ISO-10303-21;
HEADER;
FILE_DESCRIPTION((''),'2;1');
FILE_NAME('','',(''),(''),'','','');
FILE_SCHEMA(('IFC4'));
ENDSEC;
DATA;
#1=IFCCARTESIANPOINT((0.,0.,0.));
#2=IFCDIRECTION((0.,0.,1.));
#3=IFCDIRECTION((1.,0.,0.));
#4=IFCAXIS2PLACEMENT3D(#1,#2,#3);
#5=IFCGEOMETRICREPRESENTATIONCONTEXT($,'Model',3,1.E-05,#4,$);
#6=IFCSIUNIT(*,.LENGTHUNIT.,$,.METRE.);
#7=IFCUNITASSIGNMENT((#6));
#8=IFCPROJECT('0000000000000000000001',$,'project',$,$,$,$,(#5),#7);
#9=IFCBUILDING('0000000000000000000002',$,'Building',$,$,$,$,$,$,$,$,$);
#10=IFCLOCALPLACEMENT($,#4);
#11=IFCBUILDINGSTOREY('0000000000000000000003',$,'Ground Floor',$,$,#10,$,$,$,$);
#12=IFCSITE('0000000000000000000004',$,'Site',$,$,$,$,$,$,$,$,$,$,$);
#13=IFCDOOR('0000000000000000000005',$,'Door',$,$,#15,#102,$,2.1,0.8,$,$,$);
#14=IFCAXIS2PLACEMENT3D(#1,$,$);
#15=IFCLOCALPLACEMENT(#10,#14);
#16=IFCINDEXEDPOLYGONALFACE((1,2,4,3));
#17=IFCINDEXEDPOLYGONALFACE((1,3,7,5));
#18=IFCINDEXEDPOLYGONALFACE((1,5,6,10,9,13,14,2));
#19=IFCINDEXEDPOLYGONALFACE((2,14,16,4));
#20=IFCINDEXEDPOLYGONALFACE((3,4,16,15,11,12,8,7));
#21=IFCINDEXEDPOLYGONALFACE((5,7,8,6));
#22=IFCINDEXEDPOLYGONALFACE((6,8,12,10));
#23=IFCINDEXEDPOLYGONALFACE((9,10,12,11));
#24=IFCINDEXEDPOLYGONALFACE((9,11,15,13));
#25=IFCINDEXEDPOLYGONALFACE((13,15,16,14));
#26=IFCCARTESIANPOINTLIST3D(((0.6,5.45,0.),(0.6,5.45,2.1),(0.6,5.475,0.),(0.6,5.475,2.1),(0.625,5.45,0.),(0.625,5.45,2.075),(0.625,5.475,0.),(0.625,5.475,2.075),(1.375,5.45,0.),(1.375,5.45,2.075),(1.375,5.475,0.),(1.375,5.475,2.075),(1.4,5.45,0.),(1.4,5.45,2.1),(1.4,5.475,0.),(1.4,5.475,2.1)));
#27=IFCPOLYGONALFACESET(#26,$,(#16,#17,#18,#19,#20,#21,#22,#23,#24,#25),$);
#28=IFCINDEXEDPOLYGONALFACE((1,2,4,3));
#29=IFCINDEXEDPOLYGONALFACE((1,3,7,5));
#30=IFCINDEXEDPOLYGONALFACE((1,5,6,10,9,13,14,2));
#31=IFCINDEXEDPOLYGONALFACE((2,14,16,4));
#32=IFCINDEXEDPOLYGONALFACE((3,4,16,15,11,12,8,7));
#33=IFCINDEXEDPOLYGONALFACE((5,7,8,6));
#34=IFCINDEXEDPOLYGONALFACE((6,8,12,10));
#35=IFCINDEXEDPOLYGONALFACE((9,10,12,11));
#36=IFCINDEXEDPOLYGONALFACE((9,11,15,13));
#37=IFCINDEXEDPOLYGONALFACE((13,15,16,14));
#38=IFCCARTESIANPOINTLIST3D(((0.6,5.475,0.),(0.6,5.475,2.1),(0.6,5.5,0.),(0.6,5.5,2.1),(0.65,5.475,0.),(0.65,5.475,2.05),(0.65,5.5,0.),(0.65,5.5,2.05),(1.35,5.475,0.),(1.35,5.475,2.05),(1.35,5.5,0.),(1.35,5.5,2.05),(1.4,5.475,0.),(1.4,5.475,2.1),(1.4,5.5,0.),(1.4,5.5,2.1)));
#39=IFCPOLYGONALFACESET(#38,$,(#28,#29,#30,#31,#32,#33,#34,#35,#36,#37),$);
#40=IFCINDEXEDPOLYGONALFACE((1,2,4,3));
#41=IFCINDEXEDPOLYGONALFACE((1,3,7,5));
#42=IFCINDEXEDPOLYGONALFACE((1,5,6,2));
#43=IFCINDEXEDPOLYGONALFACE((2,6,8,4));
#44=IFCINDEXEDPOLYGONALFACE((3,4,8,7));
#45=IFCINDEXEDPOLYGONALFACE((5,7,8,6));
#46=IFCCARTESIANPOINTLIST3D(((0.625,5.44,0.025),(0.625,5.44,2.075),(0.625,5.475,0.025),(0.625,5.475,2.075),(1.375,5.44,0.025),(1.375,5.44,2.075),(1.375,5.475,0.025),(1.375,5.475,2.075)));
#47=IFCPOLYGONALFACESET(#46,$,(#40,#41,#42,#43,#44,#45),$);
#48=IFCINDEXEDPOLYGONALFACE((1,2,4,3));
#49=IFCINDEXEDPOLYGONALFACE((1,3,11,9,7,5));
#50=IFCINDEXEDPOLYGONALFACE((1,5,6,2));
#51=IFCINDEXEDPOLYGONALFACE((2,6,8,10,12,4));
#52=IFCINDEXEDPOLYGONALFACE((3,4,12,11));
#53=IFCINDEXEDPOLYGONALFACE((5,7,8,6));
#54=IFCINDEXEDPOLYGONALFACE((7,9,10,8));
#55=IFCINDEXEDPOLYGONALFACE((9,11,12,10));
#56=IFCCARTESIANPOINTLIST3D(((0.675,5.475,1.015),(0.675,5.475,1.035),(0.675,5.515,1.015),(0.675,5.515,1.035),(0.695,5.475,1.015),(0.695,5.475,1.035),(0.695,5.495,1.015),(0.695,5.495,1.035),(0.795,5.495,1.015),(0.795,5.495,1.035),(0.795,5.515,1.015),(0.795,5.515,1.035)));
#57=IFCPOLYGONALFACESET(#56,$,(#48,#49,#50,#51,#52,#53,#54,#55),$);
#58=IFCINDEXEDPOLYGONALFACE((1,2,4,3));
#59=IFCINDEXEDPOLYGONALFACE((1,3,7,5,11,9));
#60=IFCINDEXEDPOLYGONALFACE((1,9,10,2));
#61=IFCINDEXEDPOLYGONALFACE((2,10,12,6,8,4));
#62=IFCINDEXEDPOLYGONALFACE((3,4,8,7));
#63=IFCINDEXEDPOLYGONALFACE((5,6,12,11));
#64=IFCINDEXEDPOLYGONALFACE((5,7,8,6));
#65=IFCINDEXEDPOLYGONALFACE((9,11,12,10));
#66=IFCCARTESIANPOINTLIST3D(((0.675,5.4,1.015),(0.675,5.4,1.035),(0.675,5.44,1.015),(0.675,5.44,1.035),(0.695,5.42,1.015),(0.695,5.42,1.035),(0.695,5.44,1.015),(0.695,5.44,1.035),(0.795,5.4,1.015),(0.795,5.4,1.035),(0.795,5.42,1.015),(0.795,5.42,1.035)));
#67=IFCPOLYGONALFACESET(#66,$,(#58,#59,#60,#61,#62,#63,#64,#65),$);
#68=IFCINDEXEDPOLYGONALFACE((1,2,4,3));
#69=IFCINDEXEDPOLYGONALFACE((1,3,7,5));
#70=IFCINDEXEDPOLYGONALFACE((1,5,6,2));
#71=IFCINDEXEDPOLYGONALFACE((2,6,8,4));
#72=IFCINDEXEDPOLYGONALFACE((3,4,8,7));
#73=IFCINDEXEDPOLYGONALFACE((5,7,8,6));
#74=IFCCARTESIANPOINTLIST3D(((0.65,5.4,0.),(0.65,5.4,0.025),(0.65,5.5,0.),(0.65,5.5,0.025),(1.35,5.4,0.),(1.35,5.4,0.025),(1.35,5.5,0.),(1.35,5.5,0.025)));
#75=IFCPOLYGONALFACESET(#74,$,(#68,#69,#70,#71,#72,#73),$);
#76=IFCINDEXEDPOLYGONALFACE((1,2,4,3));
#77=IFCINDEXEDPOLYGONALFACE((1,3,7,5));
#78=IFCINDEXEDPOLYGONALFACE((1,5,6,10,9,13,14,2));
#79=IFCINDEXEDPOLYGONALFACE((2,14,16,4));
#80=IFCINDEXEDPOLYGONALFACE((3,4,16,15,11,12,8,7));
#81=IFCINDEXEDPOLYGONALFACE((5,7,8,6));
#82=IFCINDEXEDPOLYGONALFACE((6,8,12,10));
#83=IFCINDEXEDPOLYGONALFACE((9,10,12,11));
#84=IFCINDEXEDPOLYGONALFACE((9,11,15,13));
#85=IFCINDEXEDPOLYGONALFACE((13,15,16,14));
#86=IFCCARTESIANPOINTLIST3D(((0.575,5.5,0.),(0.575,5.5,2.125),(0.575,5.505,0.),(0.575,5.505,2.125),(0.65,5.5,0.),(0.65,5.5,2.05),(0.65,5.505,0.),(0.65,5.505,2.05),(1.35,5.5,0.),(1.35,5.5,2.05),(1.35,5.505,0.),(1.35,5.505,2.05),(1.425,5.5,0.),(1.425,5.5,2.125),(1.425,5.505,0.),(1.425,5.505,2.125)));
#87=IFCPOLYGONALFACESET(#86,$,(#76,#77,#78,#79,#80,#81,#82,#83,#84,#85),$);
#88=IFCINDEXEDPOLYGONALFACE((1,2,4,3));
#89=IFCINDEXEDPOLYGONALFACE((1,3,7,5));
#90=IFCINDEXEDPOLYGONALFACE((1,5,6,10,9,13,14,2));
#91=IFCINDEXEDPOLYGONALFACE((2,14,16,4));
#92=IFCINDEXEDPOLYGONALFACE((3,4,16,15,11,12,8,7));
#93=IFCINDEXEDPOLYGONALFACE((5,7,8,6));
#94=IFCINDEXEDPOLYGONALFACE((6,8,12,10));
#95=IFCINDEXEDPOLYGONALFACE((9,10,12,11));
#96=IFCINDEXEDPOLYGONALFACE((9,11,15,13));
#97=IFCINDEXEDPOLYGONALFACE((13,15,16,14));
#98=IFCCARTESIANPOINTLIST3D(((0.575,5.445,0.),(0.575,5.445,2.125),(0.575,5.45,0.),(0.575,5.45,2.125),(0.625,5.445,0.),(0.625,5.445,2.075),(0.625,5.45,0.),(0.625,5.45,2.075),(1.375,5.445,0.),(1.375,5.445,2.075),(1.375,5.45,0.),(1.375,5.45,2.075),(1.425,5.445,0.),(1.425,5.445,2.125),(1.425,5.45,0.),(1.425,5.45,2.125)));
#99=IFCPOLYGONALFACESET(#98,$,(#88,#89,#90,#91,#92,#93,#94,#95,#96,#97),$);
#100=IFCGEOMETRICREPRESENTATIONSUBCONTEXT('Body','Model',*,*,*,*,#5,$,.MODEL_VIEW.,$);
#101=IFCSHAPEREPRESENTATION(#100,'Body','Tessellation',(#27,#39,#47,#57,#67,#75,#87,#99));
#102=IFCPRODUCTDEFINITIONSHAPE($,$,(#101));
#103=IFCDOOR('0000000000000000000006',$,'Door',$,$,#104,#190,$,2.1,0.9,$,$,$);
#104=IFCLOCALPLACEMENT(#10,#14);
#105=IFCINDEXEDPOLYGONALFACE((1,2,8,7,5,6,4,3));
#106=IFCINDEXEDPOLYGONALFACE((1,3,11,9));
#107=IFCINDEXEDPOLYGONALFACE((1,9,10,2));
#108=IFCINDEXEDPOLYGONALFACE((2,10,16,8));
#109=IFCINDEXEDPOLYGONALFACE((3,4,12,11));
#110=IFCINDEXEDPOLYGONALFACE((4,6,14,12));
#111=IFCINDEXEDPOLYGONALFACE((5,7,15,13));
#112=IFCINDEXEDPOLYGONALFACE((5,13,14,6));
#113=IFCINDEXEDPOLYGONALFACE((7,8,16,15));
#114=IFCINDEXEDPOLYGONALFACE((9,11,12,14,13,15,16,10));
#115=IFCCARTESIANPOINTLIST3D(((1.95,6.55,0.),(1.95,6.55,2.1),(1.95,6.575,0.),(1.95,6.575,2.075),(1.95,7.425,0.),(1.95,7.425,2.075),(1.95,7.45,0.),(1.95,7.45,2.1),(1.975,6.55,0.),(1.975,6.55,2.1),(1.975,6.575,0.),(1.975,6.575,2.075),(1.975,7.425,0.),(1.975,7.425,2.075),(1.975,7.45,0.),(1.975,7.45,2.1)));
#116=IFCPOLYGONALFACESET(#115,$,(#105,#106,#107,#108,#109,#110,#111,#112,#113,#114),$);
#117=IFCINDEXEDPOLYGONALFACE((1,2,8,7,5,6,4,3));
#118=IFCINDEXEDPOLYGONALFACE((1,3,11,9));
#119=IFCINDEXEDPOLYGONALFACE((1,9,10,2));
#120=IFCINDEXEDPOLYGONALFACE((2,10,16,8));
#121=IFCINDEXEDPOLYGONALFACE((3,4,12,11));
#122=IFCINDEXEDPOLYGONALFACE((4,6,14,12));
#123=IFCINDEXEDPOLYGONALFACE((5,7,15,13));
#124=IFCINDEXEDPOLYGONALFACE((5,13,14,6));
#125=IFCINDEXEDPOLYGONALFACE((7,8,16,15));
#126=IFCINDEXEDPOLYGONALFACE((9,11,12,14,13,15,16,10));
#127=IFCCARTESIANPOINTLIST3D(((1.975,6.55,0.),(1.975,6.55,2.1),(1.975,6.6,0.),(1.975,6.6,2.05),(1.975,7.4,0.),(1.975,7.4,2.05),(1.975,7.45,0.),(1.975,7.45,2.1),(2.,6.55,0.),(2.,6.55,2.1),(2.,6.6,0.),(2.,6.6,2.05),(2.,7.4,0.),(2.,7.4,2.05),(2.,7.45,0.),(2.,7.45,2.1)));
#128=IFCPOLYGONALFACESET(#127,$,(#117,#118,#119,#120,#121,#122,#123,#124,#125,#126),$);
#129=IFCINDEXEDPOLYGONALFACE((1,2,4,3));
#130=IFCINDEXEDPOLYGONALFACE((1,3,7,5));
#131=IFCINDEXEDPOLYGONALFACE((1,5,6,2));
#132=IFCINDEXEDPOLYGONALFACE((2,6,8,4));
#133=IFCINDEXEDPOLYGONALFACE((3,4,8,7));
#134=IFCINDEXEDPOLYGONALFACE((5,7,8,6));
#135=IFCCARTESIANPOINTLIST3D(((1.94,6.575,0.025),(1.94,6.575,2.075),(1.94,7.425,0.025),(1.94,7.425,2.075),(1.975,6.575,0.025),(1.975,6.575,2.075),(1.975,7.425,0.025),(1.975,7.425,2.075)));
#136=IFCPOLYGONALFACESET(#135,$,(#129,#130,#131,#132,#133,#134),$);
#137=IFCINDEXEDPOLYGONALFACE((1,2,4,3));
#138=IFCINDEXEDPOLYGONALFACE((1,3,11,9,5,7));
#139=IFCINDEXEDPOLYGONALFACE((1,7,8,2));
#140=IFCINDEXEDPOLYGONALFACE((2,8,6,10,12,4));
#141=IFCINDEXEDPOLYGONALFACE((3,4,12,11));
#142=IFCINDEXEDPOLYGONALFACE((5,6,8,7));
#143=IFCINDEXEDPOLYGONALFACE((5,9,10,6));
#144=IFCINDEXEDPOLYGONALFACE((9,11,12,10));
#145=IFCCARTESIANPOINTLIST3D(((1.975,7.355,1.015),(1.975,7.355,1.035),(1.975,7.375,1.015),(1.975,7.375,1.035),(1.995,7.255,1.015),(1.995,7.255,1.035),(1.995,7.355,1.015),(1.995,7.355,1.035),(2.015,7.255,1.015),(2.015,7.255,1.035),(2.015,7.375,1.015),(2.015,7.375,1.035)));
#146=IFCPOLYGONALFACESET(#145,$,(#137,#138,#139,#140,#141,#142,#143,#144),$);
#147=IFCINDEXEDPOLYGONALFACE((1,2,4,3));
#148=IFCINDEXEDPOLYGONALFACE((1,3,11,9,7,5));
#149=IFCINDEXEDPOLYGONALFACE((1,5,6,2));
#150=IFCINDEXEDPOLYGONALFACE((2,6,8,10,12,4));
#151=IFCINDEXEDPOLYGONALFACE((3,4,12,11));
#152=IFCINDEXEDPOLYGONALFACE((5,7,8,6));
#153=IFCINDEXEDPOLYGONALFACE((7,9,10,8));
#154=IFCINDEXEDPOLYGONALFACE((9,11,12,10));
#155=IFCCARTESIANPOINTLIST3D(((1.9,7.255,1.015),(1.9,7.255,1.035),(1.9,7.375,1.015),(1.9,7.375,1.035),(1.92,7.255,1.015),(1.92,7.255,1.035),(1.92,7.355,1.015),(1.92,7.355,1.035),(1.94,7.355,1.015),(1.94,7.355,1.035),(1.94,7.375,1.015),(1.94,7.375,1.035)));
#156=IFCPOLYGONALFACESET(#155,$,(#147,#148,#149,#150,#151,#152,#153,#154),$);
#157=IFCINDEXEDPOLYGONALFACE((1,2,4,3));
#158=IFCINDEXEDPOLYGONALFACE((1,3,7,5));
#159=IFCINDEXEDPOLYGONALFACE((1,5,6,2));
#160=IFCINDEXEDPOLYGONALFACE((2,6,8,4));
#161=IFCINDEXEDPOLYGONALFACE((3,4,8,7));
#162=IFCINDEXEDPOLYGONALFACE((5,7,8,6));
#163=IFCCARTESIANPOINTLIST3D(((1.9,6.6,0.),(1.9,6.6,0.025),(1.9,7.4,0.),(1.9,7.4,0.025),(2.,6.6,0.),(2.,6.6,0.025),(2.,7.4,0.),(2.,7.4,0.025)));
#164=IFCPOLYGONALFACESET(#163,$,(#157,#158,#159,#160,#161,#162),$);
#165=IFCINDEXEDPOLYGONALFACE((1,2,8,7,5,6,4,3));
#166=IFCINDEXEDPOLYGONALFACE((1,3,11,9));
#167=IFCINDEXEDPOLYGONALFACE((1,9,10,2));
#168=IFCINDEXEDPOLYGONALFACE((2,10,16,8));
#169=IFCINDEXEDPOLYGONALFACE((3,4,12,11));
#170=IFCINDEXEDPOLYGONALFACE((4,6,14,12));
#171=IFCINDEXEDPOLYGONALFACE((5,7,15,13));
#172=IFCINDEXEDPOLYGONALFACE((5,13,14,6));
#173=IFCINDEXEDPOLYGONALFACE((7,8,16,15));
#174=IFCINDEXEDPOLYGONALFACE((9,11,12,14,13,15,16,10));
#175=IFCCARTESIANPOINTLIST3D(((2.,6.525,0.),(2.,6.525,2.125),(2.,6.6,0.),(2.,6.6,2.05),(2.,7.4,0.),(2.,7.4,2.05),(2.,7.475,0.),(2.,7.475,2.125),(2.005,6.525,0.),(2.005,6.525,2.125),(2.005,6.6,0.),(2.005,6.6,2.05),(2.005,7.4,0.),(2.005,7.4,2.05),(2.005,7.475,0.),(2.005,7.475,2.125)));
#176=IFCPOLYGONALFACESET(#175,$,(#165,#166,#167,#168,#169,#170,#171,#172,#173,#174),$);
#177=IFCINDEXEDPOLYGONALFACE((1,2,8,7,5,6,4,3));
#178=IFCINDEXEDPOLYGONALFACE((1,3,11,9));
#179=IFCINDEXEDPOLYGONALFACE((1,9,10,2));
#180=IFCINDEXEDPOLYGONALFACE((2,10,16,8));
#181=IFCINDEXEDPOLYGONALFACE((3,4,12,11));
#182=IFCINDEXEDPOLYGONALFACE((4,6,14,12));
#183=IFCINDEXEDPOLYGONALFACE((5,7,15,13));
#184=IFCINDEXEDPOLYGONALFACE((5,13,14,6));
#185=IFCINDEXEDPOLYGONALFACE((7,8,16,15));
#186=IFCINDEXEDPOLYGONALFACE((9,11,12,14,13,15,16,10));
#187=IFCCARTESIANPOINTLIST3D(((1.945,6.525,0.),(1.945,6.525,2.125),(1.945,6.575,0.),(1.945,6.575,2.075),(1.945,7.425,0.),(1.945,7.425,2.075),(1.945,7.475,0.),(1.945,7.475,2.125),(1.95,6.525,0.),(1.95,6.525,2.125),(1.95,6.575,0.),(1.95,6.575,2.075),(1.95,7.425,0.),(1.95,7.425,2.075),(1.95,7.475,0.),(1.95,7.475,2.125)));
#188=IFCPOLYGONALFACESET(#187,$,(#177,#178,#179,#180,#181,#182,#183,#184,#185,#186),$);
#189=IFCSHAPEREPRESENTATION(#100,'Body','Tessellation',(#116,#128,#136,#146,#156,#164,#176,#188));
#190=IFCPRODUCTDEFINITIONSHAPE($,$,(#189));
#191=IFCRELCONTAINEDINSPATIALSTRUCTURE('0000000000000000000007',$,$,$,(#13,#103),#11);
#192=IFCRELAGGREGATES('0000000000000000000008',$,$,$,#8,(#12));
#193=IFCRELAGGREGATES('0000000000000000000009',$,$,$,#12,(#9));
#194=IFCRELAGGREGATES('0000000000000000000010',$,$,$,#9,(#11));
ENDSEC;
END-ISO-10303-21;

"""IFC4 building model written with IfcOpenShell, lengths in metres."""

from ifc_helpers import new_model, si_unit, frame, origin_with_axes, place, context, subcontext, project, spatial, line, indexed_curve, outline, extrude, element, save


model = new_model("IFC4")

# Units and contexts
model_context = context("Model", 3, precision=1e-05, world=origin_with_axes())
body_context = subcontext(model_context, "Body", "Model", "MODEL_VIEW")
ifc_project = project(units=[si_unit("LENGTHUNIT", "METRE")], contexts=[model_context])

# Site, building, storey
site = spatial("IfcSite", under=ifc_project, Name="Site")
building = spatial("IfcBuilding", under=site, Name="Building")
storey_placement = place(None, origin_with_axes())
storey = spatial("IfcBuildingStorey", under=building, at=storey_placement, Name="Ground Floor")

# Doors
door_1_placement = place(storey_placement, frame((1.4, 5.5, 0.0), z_axis=(0.0, 0.0, 1.0), x_axis=(-1.0, 0.0, 0.0)))
element("IfcDoor", 1, at=door_1_placement, inside=storey, Name="Door", OverallHeight=2.1, OverallWidth=0.8, context=body_context, shape_type="SweptSolid", body=[
    extrude(outline(indexed_curve([(0.0, 0.0), (0.0, 2.1), (0.8, 2.1), (0.8, 0.0), (0.775, 0.0), (0.775, 2.075), (0.025, 2.075), (0.025, 0.0)], segments=[line(1, 2, 3, 4, 5, 6, 7, 8, 1)])), frame((0.0, 0.025, 0.0), z_axis=(0.0, -1.0, 0.0), x_axis=(1.0, 0.0, 0.0)), (0.0, 0.0, -1.0), 0.025),
    extrude(outline(indexed_curve([(0.0, 0.0), (0.0, 2.1), (0.8, 2.1), (0.8, 0.0), (0.75, 0.0), (0.75, 2.05), (0.05, 2.05), (0.05, 0.0)], segments=[line(1, 2, 3, 4, 5, 6, 7, 8, 1)])), frame((0.0, 0.0, 0.0), z_axis=(0.0, -1.0, 0.0), x_axis=(1.0, 0.0, 0.0)), (0.0, 0.0, -1.0), 0.025),
    extrude(outline(indexed_curve([(0.0, 0.0), (0.75, 0.0), (0.75, 0.035), (0.0, 0.035)], segments=[line(1, 2, 3, 4, 1)])), frame((0.025, 0.025, 0.025), z_axis=(0.0, 0.0, 1.0), x_axis=(1.0, 0.0, 0.0)), (0.0, 0.0, 1.0), 2.05),
    extrude(outline(indexed_curve([(0.0, 0.0), (0.0, -0.04), (-0.12, -0.04), (-0.12, -0.02), (-0.02, -0.02), (-0.02, 0.0)], segments=[line(1, 2, 3, 4, 5, 6, 1)])), frame((0.725, 0.025, 1.015), z_axis=(0.0, 0.0, 1.0), x_axis=(1.0, 0.0, 0.0)), (0.0, 0.0, 1.0), 0.02),
    extrude(outline(indexed_curve([(0.0, 0.0), (0.0, 0.04), (-0.12, 0.04), (-0.12, 0.02), (-0.02, 0.02), (-0.02, 0.0)], segments=[line(1, 2, 3, 4, 5, 6, 1)])), frame((0.725, 0.06, 1.015), z_axis=(0.0, 0.0, 1.0), x_axis=(1.0, 0.0, 0.0)), (0.0, 0.0, 1.0), 0.02),
    extrude(outline(indexed_curve([(0.0, 0.0), (0.7, 0.0), (0.7, 0.1), (0.0, 0.1)], segments=[line(1, 2, 3, 4, 1)])), frame((0.05, 0.0, 0.0), z_axis=(0.0, 0.0, 1.0), x_axis=(1.0, 0.0, 0.0)), (0.0, 0.0, 1.0), 0.025),
    extrude(outline(indexed_curve([(0.0, 0.0), (0.0, 2.125), (0.85, 2.125), (0.85, 0.0), (0.775, 0.0), (0.775, 2.05), (0.075, 2.05), (0.075, 0.0)], segments=[line(1, 2, 3, 4, 5, 6, 7, 8, 1)])), frame((-0.025, -0.005, 0.0), z_axis=(0.0, -1.0, 0.0), x_axis=(1.0, 0.0, 0.0)), (0.0, 0.0, -1.0), 0.005),
    extrude(outline(indexed_curve([(0.0, 0.0), (0.0, 2.125), (0.85, 2.125), (0.85, 0.0), (0.8, 0.0), (0.8, 2.075), (0.05, 2.075), (0.05, 0.0)], segments=[line(1, 2, 3, 4, 5, 6, 7, 8, 1)])), frame((-0.025, 0.05, 0.0), z_axis=(0.0, -1.0, 0.0), x_axis=(1.0, 0.0, 0.0)), (0.0, 0.0, -1.0), 0.005),
])
door_2_placement = place(storey_placement, frame((2.0, 6.55, 0.0), z_axis=(0.0, 0.0, 1.0), x_axis=(0.0, 1.0, 0.0)))
element("IfcDoor", 2, at=door_2_placement, inside=storey, Name="Door", OverallHeight=2.1, OverallWidth=0.9, context=body_context, shape_type="SweptSolid", body=[
    extrude(outline(indexed_curve([(0.0, 0.0), (0.0, 2.1), (0.9, 2.1), (0.9, 0.0), (0.875, 0.0), (0.875, 2.075), (0.025, 2.075), (0.025, 0.0)], segments=[line(1, 2, 3, 4, 5, 6, 7, 8, 1)])), frame((0.0, 0.025, 0.0), z_axis=(0.0, -1.0, 0.0), x_axis=(1.0, 0.0, 0.0)), (0.0, 0.0, -1.0), 0.025),
    extrude(outline(indexed_curve([(0.0, 0.0), (0.0, 2.1), (0.9, 2.1), (0.9, 0.0), (0.85, 0.0), (0.85, 2.05), (0.05, 2.05), (0.05, 0.0)], segments=[line(1, 2, 3, 4, 5, 6, 7, 8, 1)])), frame((0.0, 0.0, 0.0), z_axis=(0.0, -1.0, 0.0), x_axis=(1.0, 0.0, 0.0)), (0.0, 0.0, -1.0), 0.025),
    extrude(outline(indexed_curve([(0.0, 0.0), (0.85, 0.0), (0.85, 0.035), (0.0, 0.035)], segments=[line(1, 2, 3, 4, 1)])), frame((0.025, 0.025, 0.025), z_axis=(0.0, 0.0, 1.0), x_axis=(1.0, 0.0, 0.0)), (0.0, 0.0, 1.0), 2.05),
    extrude(outline(indexed_curve([(0.0, 0.0), (0.0, -0.04), (-0.12, -0.04), (-0.12, -0.02), (-0.02, -0.02), (-0.02, 0.0)], segments=[line(1, 2, 3, 4, 5, 6, 1)])), frame((0.825, 0.025, 1.015), z_axis=(0.0, 0.0, 1.0), x_axis=(1.0, 0.0, 0.0)), (0.0, 0.0, 1.0), 0.02),
    extrude(outline(indexed_curve([(0.0, 0.0), (0.0, 0.04), (-0.12, 0.04), (-0.12, 0.02), (-0.02, 0.02), (-0.02, 0.0)], segments=[line(1, 2, 3, 4, 5, 6, 1)])), frame((0.825, 0.06, 1.015), z_axis=(0.0, 0.0, 1.0), x_axis=(1.0, 0.0, 0.0)), (0.0, 0.0, 1.0), 0.02),
    extrude(outline(indexed_curve([(0.0, 0.0), (0.8, 0.0), (0.8, 0.1), (0.0, 0.1)], segments=[line(1, 2, 3, 4, 1)])), frame((0.05, 0.0, 0.0), z_axis=(0.0, 0.0, 1.0), x_axis=(1.0, 0.0, 0.0)), (0.0, 0.0, 1.0), 0.025),
    extrude(outline(indexed_curve([(0.0, 0.0), (0.0, 2.125), (0.95, 2.125), (0.95, 0.0), (0.875, 0.0), (0.875, 2.05), (0.075, 2.05), (0.075, 0.0)], segments=[line(1, 2, 3, 4, 5, 6, 7, 8, 1)])), frame((-0.025, -0.005, 0.0), z_axis=(0.0, -1.0, 0.0), x_axis=(1.0, 0.0, 0.0)), (0.0, 0.0, -1.0), 0.005),
    extrude(outline(indexed_curve([(0.0, 0.0), (0.0, 2.125), (0.95, 2.125), (0.95, 0.0), (0.9, 0.0), (0.9, 2.075), (0.05, 2.075), (0.05, 0.0)], segments=[line(1, 2, 3, 4, 5, 6, 7, 8, 1)])), frame((-0.025, 0.05, 0.0), z_axis=(0.0, -1.0, 0.0), x_axis=(1.0, 0.0, 0.0)), (0.0, 0.0, -1.0), 0.005),
])

save(model, "model.ifc")
